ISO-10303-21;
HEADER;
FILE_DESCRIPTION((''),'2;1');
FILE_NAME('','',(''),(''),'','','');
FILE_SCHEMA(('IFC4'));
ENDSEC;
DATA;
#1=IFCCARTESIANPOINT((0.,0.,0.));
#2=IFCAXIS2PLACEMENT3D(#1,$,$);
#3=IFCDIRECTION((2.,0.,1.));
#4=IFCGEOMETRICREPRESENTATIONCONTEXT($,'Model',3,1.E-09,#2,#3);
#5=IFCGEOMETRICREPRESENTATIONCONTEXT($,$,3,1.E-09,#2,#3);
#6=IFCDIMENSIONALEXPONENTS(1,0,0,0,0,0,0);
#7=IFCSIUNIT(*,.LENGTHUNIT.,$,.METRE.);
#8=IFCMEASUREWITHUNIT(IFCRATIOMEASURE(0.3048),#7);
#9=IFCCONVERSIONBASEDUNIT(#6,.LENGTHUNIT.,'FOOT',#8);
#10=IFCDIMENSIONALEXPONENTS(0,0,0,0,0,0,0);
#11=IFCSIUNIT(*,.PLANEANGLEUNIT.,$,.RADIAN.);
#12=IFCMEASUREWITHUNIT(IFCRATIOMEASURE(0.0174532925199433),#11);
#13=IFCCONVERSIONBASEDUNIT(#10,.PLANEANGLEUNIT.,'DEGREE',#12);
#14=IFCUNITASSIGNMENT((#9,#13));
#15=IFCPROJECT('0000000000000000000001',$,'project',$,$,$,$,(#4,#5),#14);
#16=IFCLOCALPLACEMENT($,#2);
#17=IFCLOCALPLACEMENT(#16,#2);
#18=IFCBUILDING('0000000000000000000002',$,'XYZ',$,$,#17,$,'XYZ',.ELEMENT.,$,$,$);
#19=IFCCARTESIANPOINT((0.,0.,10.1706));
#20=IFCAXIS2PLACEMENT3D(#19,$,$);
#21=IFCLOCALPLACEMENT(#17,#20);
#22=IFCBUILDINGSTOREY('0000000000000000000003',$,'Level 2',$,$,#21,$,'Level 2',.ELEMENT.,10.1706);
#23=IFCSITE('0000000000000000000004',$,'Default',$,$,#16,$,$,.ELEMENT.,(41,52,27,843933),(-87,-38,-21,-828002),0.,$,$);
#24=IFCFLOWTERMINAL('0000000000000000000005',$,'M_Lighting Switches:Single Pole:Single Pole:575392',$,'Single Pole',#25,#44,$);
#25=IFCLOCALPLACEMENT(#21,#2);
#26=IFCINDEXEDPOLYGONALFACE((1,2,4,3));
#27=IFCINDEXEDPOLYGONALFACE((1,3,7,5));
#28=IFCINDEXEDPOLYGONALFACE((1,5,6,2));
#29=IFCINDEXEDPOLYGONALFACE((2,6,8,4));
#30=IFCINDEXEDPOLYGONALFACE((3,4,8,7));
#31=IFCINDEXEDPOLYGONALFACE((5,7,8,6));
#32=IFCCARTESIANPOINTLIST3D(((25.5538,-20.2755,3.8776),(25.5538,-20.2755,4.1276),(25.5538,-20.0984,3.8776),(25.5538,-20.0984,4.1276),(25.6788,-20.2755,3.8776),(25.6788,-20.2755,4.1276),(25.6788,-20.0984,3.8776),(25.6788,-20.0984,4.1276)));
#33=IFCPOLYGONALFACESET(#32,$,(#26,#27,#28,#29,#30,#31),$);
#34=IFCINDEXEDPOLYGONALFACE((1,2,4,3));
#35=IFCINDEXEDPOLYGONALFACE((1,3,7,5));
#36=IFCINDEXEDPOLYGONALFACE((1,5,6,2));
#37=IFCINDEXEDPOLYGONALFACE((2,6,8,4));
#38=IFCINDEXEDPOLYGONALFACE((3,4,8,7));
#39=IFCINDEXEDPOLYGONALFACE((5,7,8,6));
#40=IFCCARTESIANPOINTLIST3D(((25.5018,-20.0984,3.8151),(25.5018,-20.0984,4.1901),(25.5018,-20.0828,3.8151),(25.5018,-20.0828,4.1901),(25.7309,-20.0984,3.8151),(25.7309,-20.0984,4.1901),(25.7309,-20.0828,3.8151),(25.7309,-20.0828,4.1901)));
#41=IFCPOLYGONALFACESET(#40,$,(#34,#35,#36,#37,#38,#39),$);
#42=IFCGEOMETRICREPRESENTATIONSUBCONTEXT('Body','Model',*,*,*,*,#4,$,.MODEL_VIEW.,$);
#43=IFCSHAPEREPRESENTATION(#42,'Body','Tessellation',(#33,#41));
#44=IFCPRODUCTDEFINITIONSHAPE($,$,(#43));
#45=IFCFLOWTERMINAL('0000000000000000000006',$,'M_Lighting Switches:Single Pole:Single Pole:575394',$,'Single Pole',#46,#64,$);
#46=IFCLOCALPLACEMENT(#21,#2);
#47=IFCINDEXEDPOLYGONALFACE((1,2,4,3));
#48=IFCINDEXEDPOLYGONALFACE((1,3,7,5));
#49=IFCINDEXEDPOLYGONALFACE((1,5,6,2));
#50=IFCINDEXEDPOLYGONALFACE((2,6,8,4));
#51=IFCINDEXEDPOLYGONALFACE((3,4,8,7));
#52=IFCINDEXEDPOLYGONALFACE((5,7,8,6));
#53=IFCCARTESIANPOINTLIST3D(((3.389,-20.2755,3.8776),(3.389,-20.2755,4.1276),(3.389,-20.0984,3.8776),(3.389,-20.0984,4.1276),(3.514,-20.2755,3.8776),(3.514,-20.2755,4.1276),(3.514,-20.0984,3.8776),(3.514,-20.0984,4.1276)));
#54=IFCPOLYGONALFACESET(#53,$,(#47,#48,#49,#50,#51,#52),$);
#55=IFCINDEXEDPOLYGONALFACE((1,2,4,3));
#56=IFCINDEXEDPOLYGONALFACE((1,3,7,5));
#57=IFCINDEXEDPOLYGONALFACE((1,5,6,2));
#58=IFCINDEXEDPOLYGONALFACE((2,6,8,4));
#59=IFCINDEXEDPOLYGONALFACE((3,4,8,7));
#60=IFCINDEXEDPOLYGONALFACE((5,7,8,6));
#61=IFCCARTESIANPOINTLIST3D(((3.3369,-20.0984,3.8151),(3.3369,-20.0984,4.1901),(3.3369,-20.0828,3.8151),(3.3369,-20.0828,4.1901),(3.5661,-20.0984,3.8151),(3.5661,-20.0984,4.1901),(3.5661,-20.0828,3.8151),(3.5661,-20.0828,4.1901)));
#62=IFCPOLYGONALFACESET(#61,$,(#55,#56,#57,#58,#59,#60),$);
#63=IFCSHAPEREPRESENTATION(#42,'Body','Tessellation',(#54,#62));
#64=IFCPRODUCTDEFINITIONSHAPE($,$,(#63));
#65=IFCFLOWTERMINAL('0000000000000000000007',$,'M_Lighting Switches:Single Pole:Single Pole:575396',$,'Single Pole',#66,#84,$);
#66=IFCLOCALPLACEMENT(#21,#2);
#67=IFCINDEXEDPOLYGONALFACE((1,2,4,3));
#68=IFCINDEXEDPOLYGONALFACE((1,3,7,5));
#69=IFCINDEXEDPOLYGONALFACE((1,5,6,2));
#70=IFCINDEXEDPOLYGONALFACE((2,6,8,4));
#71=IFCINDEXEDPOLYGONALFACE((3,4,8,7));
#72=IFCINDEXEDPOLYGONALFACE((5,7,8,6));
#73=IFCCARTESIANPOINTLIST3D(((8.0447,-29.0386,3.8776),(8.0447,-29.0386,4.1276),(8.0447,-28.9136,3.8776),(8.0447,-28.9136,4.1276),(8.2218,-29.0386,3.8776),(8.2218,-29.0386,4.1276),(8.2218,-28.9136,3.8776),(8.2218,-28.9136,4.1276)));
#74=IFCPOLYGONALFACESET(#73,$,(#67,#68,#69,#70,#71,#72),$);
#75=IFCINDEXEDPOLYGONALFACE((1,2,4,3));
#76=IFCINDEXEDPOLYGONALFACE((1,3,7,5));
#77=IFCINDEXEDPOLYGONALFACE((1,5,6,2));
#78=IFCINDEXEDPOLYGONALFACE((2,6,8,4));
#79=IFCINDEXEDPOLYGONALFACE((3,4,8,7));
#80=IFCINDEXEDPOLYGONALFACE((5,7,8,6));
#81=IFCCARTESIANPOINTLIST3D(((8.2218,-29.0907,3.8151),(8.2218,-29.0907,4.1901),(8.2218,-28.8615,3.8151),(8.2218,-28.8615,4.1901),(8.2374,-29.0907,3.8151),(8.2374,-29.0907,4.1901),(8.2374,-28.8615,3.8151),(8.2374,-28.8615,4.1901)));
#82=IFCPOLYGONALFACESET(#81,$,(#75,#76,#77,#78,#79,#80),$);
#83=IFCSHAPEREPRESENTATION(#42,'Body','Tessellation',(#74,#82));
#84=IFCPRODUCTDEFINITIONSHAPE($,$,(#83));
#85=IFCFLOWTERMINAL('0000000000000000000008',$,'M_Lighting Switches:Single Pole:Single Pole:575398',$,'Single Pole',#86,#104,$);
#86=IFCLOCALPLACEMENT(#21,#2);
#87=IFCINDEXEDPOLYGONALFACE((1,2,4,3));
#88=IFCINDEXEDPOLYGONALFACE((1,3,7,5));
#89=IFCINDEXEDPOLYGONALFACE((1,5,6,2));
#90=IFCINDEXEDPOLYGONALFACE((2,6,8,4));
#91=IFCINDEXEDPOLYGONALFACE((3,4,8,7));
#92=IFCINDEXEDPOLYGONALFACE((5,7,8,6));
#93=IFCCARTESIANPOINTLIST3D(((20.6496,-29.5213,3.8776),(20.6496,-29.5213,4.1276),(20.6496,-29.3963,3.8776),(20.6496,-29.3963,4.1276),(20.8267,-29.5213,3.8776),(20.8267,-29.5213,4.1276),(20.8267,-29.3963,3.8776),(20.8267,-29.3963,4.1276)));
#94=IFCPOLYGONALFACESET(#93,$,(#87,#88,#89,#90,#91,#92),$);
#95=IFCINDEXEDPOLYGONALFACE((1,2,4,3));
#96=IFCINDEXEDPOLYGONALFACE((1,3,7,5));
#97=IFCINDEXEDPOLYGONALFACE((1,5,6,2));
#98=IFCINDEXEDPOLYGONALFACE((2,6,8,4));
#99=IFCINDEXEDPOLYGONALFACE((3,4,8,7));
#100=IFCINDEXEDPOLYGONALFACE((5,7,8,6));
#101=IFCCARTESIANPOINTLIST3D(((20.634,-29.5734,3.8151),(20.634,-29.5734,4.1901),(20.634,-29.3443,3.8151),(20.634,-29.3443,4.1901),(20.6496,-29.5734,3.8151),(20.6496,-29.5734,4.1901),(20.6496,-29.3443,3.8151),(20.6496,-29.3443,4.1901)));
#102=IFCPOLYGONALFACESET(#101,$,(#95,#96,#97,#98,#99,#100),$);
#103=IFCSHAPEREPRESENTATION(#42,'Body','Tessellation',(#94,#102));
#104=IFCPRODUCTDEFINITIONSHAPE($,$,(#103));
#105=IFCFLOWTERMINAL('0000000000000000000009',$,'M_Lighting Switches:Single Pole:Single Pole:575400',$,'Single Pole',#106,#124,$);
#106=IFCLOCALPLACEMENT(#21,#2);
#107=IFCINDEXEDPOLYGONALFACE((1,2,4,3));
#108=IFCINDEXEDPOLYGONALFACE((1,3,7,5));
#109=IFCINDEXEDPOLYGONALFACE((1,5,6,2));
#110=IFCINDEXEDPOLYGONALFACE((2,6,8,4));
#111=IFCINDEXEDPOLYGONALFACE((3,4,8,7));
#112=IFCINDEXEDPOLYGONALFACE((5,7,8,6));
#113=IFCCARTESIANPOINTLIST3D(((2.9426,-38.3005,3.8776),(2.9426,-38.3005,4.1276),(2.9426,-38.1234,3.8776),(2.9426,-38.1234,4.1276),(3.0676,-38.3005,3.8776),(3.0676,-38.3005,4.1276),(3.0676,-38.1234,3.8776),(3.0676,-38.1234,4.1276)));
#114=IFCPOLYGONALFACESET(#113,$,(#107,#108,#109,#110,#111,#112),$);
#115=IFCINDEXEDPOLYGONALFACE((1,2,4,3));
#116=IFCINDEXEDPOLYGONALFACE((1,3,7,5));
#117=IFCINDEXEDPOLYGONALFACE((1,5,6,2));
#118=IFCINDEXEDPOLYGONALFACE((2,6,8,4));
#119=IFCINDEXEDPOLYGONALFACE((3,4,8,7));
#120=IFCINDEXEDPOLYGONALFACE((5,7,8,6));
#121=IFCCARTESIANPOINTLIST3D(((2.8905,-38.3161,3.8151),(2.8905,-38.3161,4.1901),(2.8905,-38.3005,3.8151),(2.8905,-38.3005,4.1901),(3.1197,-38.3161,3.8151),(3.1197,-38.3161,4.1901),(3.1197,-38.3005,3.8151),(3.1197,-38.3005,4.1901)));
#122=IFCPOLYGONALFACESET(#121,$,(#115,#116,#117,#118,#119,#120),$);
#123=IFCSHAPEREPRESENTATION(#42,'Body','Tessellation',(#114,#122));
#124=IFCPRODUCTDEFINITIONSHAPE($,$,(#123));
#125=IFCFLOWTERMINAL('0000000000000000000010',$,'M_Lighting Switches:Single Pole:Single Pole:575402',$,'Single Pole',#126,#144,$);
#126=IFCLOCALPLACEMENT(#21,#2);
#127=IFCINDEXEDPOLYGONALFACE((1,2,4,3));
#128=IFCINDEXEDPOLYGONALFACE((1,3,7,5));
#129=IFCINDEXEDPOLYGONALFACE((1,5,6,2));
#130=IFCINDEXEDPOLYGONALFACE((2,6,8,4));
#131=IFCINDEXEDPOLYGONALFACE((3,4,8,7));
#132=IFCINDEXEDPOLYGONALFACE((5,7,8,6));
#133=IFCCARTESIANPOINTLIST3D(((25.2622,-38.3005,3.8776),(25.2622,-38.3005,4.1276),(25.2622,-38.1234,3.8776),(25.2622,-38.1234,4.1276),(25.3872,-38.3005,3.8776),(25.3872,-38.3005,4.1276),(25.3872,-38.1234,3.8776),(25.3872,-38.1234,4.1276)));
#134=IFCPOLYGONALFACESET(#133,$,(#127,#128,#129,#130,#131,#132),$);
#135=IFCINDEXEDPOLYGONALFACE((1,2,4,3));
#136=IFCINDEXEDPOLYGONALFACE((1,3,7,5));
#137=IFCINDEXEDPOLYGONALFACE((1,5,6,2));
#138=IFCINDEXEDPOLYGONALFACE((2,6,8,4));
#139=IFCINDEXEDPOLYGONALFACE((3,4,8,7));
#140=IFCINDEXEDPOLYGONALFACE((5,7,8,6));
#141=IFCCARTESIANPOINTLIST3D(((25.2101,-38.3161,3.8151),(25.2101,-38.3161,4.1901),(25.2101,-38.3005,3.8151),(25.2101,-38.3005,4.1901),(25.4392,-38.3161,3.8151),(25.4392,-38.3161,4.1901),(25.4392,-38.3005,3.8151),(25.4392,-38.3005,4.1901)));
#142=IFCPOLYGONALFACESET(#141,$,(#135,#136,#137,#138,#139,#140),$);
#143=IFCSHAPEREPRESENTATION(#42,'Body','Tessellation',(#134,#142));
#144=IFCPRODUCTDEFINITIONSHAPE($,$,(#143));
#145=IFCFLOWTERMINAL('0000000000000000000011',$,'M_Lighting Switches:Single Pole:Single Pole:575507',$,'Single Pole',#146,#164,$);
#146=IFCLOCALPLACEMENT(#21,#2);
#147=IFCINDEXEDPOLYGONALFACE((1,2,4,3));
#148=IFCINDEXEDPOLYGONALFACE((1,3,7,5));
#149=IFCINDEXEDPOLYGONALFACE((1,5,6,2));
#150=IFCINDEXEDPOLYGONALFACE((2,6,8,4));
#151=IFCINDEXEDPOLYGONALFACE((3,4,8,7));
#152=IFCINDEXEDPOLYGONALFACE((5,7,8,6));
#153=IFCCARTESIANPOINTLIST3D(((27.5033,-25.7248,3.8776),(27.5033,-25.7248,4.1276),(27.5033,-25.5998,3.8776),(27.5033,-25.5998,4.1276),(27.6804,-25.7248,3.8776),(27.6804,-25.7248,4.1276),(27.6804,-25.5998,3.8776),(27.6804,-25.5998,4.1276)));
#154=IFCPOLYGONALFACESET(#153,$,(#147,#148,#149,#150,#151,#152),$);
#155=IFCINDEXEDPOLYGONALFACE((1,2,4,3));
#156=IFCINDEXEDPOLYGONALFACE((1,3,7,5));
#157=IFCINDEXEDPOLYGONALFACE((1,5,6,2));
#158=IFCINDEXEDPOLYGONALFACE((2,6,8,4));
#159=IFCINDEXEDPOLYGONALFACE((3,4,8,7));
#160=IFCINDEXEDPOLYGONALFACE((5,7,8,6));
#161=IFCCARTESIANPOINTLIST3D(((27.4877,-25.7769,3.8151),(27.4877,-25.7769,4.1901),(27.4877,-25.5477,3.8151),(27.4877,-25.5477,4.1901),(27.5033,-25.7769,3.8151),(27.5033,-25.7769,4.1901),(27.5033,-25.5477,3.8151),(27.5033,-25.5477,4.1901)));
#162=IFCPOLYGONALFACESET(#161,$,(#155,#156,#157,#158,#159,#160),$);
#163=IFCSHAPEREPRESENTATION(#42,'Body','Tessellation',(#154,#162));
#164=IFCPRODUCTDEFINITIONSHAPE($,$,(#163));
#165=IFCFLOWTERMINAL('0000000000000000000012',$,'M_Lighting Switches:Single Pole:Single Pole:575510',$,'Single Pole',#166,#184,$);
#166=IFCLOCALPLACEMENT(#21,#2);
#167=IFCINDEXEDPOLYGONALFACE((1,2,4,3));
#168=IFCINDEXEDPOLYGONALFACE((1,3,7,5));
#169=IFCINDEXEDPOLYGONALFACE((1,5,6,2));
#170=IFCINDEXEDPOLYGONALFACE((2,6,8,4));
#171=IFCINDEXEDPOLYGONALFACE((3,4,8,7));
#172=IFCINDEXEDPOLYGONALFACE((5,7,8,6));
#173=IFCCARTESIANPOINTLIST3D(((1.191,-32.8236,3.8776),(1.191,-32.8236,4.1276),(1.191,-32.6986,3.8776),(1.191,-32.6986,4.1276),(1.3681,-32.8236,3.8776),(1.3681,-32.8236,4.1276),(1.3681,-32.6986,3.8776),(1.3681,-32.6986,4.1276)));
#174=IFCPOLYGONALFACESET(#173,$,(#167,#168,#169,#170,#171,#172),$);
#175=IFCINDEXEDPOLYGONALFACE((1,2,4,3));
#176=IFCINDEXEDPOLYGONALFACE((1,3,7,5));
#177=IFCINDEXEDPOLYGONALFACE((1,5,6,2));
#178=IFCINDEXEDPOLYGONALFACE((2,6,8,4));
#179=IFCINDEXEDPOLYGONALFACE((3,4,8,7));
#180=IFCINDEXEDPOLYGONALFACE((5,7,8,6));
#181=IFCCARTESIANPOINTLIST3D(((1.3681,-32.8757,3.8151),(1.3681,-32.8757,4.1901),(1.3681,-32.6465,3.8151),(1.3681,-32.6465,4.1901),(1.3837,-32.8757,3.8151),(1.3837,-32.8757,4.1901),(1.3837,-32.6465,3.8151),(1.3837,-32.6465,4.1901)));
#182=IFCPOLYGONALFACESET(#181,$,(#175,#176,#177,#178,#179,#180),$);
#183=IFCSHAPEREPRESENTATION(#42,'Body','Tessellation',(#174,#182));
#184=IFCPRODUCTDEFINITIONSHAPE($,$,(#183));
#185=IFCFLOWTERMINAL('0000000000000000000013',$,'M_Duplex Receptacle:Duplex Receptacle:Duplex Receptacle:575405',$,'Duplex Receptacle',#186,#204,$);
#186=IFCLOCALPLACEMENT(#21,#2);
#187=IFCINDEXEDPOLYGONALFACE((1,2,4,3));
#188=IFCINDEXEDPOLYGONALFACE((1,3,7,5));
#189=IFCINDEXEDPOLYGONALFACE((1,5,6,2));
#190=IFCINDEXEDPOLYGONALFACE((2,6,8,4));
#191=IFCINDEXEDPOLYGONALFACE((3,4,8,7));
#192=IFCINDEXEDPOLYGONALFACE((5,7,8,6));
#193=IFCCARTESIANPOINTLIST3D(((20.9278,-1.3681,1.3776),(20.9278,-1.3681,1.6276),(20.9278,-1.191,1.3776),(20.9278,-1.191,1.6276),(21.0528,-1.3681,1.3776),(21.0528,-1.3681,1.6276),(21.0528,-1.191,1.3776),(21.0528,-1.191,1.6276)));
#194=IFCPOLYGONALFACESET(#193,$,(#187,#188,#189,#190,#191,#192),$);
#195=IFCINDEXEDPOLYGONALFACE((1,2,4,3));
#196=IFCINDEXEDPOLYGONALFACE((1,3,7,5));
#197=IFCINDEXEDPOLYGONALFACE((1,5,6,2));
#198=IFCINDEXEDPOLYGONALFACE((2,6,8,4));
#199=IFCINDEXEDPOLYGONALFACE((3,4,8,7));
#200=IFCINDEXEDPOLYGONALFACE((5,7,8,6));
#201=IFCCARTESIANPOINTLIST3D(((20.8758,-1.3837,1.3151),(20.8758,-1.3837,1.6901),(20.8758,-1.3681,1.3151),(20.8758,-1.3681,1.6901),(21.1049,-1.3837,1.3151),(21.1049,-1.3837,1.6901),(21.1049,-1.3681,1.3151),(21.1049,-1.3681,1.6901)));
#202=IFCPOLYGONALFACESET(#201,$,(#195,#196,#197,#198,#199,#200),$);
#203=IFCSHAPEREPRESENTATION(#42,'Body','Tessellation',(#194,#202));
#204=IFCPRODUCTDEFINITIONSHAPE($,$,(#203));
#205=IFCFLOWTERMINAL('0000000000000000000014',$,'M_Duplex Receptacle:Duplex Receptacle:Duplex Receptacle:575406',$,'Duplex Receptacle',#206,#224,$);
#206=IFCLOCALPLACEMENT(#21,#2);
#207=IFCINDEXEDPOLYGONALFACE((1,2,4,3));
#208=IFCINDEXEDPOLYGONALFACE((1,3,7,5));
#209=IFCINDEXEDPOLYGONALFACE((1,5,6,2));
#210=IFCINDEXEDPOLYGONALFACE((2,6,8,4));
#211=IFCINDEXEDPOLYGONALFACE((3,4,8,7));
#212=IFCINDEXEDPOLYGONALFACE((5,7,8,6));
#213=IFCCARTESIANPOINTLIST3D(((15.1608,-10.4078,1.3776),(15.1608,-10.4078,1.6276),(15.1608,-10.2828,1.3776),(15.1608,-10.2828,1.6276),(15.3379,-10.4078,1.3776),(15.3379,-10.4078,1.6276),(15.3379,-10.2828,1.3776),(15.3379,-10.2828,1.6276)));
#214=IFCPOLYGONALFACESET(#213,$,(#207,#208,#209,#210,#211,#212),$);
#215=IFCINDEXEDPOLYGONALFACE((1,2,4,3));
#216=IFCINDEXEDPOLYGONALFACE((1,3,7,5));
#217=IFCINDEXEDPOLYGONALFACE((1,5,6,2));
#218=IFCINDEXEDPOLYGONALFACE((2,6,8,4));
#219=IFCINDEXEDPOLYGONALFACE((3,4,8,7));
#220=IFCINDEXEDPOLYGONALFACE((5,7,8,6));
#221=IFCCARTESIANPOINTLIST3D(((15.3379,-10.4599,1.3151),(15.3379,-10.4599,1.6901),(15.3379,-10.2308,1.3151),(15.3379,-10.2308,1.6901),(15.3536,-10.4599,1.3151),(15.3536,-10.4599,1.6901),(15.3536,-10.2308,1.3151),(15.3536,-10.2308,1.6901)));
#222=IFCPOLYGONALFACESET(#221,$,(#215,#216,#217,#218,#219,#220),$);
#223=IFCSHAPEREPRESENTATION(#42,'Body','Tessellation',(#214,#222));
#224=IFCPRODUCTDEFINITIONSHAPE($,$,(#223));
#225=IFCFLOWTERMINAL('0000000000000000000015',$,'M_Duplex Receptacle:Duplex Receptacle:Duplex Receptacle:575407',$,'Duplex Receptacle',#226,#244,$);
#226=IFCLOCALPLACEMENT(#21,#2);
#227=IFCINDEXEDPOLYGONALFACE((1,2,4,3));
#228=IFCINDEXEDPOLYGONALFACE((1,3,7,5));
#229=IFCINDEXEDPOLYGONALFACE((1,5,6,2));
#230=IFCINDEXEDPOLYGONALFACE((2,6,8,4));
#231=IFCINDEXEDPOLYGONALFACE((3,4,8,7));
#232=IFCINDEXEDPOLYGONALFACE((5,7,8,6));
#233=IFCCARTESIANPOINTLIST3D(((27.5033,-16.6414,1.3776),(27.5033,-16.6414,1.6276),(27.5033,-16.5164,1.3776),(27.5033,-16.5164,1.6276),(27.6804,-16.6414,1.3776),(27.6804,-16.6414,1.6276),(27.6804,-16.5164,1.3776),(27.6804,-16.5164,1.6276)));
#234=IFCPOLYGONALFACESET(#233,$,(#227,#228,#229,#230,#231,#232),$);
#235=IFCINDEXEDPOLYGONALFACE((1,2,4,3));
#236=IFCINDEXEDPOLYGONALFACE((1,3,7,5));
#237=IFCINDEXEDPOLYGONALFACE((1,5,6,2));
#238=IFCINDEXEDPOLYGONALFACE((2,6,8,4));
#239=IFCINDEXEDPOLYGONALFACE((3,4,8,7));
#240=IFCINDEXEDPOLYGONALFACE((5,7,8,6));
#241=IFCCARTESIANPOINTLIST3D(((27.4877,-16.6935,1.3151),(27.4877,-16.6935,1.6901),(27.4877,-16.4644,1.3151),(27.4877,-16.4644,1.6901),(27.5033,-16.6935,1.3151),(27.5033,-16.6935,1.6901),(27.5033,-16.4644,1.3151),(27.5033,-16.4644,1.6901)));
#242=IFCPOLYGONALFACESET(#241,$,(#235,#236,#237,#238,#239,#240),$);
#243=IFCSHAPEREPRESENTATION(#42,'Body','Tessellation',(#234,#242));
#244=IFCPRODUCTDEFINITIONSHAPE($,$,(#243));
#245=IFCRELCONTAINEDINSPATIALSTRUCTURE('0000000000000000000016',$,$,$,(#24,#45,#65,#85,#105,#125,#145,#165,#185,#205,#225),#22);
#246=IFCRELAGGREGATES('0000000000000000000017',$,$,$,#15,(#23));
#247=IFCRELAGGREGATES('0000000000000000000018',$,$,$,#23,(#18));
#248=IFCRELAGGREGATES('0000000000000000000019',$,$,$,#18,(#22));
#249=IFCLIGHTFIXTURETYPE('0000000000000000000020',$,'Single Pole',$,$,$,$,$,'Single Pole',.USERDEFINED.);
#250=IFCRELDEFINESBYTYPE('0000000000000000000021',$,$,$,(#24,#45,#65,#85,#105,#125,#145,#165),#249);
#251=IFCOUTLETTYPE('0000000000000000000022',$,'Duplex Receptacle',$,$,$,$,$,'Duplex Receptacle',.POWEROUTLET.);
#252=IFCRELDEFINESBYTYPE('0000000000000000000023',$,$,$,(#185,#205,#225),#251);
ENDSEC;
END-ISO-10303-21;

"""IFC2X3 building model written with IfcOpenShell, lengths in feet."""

from ifc_helpers import new_model, entity, si_unit, converted_unit, direction, frame, frame_2d, origin, origin_2d_with_axis, place, context, subcontext, project, spatial, rectangle, extrude, source, transform, mapped, type_object, type_shapes, element, save


model = new_model("IFC2X3")

# Units and contexts
model_context = context("Model", 3, precision=1e-09, world=origin(), true_north=direction((2.0, 0.0, 1.0)))
context_of_model = context(None, 3, precision=1e-09, world=origin(), true_north=direction((2.0, 0.0, 1.0)))
body_context = subcontext(model_context, "Body", "Model", "MODEL_VIEW")
ifc_project = project(units=[converted_unit("LENGTHUNIT", "FOOT", entity("IfcRatioMeasure", 0.3048), si_unit("LENGTHUNIT", "METRE"), dimensions=[1, 0, 0, 0, 0, 0, 0]), converted_unit("PLANEANGLEUNIT", "DEGREE", entity("IfcRatioMeasure", 0.0174532925199433), si_unit("PLANEANGLEUNIT", "RADIAN"), dimensions=[0, 0, 0, 0, 0, 0, 0])], contexts=[model_context, context_of_model])

# Site, building, storey
site_placement = place(None, origin())
site = spatial("IfcSite", under=ifc_project, at=site_placement, Name="Default", CompositionType="ELEMENT", RefLatitude=(41, 52, 27, 843933), RefLongitude=(-87, -38, -21, -828002), RefElevation=0.0)
building_placement = place(site_placement, origin())
building = spatial("IfcBuilding", under=site, at=building_placement, Name="XYZ", LongName="XYZ", CompositionType="ELEMENT")
storey_placement = place(building_placement, frame((0.0, 0.0, 10.1706)))
storey = spatial("IfcBuildingStorey", under=building, at=storey_placement, Name="Level 2", LongName="Level 2", CompositionType="ELEMENT", Elevation=10.1706)

# Flow terminals
light_fixture_type = type_object("IfcLightFixtureType", Name="Single Pole", ElementType="Single Pole", PredefinedType="USERDEFINED")
shared_shape_1 = source(origin(), body_context, "Body", "SweptSolid", [
    extrude(rectangle(XDim=0.125, YDim=0.25, at=origin_2d_with_axis()), frame((0.0, 0.0, -0.1771), z_axis=(0.0, 0.0, 1.0), x_axis=(-1.0, 0.0, 0.0)), (0.0, 0.0, 1.0), 0.1771),
    extrude(rectangle(XDim=0.2292, YDim=0.375, at=frame_2d((0.0, 0.0), x_axis=(1.0, 0.0))), frame((0.0, 0.0, 0.0), z_axis=(0.0, 0.0, 1.0), x_axis=(-1.0, 0.0, 0.0)), (0.0, 0.0, 1.0), 0.0156),
])
type_shapes(light_fixture_type, [shared_shape_1])
for number, where, z_axis, x_axis, name in (
    (1, (25.6163, -20.0984, 4.0026), (0.0, 1.0, 0.0), (-1.0, 0.0, 0.0), "M_Lighting Switches:Single Pole:Single Pole:575392"),
    (2, (3.4515, -20.0984, 4.0026), (0.0, 1.0, 0.0), (-1.0, 0.0, 0.0), "M_Lighting Switches:Single Pole:Single Pole:575394"),
    (3, (8.2218, -28.9761, 4.0026), (1.0, 0.0, 0.0), (0.0, 1.0, 0.0), "M_Lighting Switches:Single Pole:Single Pole:575396"),
    (4, (20.6496, -29.4588, 4.0026), (-1.0, 0.0, 0.0), (0.0, -1.0, 0.0), "M_Lighting Switches:Single Pole:Single Pole:575398"),
    (5, (3.0051, -38.3005, 4.0026), (0.0, -1.0, 0.0), (1.0, 0.0, 0.0), "M_Lighting Switches:Single Pole:Single Pole:575400"),
    (6, (25.3247, -38.3005, 4.0026), (0.0, -1.0, 0.0), (1.0, 0.0, 0.0), "M_Lighting Switches:Single Pole:Single Pole:575402"),
    (7, (27.5033, -25.6623, 4.0026), (-1.0, 0.0, 0.0), (0.0, -1.0, 0.0), "M_Lighting Switches:Single Pole:Single Pole:575507"),
    (8, (1.3681, -32.7611, 4.0026), (1.0, 0.0, 0.0), (0.0, 1.0, 0.0), "M_Lighting Switches:Single Pole:Single Pole:575510"),
):
    element("IfcFlowTerminal", number, at=place(storey_placement, frame(where, z_axis=z_axis, x_axis=x_axis)), inside=storey, type_object=light_fixture_type, Name=name, ObjectType="Single Pole", context=body_context, shape_type="MappedRepresentation", body=[
        mapped(shared_shape_1, transform((0.0, 0.0, 0.0), scale=1.0)),
    ])
outlet_type = type_object("IfcOutletType", Name="Duplex Receptacle", ElementType="Duplex Receptacle", PredefinedType="POWEROUTLET")
shared_shape_2 = source(origin(), body_context, "Body", "SweptSolid", [
    extrude(rectangle(XDim=0.125, YDim=0.25, at=origin_2d_with_axis()), frame((0.0, 0.0, -0.1771), z_axis=(0.0, 0.0, 1.0), x_axis=(-1.0, 0.0, 0.0)), (0.0, 0.0, 1.0), 0.1771),
    extrude(rectangle(XDim=0.2292, YDim=0.375, at=frame_2d((0.0, 0.0), x_axis=(1.0, 0.0))), frame((0.0, 0.0, 0.0), z_axis=(0.0, 0.0, 1.0), x_axis=(-1.0, 0.0, 0.0)), (0.0, 0.0, 1.0), 0.0156),
])
type_shapes(outlet_type, [shared_shape_2])
for number, where, z_axis, x_axis, name in (
    (9, (20.9903, -1.3681, 1.5026), (0.0, -1.0, 0.0), (1.0, 0.0, 0.0), "M_Duplex Receptacle:Duplex Receptacle:Duplex Receptacle:575405"),
    (10, (15.3379, -10.3453, 1.5026), (1.0, 0.0, 0.0), (0.0, 1.0, 0.0), "M_Duplex Receptacle:Duplex Receptacle:Duplex Receptacle:575406"),
    (11, (27.5033, -16.5789, 1.5026), (-1.0, 0.0, 0.0), (0.0, -1.0, 0.0), "M_Duplex Receptacle:Duplex Receptacle:Duplex Receptacle:575407"),
):
    element("IfcFlowTerminal", number, at=place(storey_placement, frame(where, z_axis=z_axis, x_axis=x_axis)), inside=storey, type_object=outlet_type, Name=name, ObjectType="Duplex Receptacle", context=body_context, shape_type="MappedRepresentation", body=[
        mapped(shared_shape_2, transform((0.0, 0.0, 0.0), scale=1.0)),
    ])

save(model, "model.ifc")
